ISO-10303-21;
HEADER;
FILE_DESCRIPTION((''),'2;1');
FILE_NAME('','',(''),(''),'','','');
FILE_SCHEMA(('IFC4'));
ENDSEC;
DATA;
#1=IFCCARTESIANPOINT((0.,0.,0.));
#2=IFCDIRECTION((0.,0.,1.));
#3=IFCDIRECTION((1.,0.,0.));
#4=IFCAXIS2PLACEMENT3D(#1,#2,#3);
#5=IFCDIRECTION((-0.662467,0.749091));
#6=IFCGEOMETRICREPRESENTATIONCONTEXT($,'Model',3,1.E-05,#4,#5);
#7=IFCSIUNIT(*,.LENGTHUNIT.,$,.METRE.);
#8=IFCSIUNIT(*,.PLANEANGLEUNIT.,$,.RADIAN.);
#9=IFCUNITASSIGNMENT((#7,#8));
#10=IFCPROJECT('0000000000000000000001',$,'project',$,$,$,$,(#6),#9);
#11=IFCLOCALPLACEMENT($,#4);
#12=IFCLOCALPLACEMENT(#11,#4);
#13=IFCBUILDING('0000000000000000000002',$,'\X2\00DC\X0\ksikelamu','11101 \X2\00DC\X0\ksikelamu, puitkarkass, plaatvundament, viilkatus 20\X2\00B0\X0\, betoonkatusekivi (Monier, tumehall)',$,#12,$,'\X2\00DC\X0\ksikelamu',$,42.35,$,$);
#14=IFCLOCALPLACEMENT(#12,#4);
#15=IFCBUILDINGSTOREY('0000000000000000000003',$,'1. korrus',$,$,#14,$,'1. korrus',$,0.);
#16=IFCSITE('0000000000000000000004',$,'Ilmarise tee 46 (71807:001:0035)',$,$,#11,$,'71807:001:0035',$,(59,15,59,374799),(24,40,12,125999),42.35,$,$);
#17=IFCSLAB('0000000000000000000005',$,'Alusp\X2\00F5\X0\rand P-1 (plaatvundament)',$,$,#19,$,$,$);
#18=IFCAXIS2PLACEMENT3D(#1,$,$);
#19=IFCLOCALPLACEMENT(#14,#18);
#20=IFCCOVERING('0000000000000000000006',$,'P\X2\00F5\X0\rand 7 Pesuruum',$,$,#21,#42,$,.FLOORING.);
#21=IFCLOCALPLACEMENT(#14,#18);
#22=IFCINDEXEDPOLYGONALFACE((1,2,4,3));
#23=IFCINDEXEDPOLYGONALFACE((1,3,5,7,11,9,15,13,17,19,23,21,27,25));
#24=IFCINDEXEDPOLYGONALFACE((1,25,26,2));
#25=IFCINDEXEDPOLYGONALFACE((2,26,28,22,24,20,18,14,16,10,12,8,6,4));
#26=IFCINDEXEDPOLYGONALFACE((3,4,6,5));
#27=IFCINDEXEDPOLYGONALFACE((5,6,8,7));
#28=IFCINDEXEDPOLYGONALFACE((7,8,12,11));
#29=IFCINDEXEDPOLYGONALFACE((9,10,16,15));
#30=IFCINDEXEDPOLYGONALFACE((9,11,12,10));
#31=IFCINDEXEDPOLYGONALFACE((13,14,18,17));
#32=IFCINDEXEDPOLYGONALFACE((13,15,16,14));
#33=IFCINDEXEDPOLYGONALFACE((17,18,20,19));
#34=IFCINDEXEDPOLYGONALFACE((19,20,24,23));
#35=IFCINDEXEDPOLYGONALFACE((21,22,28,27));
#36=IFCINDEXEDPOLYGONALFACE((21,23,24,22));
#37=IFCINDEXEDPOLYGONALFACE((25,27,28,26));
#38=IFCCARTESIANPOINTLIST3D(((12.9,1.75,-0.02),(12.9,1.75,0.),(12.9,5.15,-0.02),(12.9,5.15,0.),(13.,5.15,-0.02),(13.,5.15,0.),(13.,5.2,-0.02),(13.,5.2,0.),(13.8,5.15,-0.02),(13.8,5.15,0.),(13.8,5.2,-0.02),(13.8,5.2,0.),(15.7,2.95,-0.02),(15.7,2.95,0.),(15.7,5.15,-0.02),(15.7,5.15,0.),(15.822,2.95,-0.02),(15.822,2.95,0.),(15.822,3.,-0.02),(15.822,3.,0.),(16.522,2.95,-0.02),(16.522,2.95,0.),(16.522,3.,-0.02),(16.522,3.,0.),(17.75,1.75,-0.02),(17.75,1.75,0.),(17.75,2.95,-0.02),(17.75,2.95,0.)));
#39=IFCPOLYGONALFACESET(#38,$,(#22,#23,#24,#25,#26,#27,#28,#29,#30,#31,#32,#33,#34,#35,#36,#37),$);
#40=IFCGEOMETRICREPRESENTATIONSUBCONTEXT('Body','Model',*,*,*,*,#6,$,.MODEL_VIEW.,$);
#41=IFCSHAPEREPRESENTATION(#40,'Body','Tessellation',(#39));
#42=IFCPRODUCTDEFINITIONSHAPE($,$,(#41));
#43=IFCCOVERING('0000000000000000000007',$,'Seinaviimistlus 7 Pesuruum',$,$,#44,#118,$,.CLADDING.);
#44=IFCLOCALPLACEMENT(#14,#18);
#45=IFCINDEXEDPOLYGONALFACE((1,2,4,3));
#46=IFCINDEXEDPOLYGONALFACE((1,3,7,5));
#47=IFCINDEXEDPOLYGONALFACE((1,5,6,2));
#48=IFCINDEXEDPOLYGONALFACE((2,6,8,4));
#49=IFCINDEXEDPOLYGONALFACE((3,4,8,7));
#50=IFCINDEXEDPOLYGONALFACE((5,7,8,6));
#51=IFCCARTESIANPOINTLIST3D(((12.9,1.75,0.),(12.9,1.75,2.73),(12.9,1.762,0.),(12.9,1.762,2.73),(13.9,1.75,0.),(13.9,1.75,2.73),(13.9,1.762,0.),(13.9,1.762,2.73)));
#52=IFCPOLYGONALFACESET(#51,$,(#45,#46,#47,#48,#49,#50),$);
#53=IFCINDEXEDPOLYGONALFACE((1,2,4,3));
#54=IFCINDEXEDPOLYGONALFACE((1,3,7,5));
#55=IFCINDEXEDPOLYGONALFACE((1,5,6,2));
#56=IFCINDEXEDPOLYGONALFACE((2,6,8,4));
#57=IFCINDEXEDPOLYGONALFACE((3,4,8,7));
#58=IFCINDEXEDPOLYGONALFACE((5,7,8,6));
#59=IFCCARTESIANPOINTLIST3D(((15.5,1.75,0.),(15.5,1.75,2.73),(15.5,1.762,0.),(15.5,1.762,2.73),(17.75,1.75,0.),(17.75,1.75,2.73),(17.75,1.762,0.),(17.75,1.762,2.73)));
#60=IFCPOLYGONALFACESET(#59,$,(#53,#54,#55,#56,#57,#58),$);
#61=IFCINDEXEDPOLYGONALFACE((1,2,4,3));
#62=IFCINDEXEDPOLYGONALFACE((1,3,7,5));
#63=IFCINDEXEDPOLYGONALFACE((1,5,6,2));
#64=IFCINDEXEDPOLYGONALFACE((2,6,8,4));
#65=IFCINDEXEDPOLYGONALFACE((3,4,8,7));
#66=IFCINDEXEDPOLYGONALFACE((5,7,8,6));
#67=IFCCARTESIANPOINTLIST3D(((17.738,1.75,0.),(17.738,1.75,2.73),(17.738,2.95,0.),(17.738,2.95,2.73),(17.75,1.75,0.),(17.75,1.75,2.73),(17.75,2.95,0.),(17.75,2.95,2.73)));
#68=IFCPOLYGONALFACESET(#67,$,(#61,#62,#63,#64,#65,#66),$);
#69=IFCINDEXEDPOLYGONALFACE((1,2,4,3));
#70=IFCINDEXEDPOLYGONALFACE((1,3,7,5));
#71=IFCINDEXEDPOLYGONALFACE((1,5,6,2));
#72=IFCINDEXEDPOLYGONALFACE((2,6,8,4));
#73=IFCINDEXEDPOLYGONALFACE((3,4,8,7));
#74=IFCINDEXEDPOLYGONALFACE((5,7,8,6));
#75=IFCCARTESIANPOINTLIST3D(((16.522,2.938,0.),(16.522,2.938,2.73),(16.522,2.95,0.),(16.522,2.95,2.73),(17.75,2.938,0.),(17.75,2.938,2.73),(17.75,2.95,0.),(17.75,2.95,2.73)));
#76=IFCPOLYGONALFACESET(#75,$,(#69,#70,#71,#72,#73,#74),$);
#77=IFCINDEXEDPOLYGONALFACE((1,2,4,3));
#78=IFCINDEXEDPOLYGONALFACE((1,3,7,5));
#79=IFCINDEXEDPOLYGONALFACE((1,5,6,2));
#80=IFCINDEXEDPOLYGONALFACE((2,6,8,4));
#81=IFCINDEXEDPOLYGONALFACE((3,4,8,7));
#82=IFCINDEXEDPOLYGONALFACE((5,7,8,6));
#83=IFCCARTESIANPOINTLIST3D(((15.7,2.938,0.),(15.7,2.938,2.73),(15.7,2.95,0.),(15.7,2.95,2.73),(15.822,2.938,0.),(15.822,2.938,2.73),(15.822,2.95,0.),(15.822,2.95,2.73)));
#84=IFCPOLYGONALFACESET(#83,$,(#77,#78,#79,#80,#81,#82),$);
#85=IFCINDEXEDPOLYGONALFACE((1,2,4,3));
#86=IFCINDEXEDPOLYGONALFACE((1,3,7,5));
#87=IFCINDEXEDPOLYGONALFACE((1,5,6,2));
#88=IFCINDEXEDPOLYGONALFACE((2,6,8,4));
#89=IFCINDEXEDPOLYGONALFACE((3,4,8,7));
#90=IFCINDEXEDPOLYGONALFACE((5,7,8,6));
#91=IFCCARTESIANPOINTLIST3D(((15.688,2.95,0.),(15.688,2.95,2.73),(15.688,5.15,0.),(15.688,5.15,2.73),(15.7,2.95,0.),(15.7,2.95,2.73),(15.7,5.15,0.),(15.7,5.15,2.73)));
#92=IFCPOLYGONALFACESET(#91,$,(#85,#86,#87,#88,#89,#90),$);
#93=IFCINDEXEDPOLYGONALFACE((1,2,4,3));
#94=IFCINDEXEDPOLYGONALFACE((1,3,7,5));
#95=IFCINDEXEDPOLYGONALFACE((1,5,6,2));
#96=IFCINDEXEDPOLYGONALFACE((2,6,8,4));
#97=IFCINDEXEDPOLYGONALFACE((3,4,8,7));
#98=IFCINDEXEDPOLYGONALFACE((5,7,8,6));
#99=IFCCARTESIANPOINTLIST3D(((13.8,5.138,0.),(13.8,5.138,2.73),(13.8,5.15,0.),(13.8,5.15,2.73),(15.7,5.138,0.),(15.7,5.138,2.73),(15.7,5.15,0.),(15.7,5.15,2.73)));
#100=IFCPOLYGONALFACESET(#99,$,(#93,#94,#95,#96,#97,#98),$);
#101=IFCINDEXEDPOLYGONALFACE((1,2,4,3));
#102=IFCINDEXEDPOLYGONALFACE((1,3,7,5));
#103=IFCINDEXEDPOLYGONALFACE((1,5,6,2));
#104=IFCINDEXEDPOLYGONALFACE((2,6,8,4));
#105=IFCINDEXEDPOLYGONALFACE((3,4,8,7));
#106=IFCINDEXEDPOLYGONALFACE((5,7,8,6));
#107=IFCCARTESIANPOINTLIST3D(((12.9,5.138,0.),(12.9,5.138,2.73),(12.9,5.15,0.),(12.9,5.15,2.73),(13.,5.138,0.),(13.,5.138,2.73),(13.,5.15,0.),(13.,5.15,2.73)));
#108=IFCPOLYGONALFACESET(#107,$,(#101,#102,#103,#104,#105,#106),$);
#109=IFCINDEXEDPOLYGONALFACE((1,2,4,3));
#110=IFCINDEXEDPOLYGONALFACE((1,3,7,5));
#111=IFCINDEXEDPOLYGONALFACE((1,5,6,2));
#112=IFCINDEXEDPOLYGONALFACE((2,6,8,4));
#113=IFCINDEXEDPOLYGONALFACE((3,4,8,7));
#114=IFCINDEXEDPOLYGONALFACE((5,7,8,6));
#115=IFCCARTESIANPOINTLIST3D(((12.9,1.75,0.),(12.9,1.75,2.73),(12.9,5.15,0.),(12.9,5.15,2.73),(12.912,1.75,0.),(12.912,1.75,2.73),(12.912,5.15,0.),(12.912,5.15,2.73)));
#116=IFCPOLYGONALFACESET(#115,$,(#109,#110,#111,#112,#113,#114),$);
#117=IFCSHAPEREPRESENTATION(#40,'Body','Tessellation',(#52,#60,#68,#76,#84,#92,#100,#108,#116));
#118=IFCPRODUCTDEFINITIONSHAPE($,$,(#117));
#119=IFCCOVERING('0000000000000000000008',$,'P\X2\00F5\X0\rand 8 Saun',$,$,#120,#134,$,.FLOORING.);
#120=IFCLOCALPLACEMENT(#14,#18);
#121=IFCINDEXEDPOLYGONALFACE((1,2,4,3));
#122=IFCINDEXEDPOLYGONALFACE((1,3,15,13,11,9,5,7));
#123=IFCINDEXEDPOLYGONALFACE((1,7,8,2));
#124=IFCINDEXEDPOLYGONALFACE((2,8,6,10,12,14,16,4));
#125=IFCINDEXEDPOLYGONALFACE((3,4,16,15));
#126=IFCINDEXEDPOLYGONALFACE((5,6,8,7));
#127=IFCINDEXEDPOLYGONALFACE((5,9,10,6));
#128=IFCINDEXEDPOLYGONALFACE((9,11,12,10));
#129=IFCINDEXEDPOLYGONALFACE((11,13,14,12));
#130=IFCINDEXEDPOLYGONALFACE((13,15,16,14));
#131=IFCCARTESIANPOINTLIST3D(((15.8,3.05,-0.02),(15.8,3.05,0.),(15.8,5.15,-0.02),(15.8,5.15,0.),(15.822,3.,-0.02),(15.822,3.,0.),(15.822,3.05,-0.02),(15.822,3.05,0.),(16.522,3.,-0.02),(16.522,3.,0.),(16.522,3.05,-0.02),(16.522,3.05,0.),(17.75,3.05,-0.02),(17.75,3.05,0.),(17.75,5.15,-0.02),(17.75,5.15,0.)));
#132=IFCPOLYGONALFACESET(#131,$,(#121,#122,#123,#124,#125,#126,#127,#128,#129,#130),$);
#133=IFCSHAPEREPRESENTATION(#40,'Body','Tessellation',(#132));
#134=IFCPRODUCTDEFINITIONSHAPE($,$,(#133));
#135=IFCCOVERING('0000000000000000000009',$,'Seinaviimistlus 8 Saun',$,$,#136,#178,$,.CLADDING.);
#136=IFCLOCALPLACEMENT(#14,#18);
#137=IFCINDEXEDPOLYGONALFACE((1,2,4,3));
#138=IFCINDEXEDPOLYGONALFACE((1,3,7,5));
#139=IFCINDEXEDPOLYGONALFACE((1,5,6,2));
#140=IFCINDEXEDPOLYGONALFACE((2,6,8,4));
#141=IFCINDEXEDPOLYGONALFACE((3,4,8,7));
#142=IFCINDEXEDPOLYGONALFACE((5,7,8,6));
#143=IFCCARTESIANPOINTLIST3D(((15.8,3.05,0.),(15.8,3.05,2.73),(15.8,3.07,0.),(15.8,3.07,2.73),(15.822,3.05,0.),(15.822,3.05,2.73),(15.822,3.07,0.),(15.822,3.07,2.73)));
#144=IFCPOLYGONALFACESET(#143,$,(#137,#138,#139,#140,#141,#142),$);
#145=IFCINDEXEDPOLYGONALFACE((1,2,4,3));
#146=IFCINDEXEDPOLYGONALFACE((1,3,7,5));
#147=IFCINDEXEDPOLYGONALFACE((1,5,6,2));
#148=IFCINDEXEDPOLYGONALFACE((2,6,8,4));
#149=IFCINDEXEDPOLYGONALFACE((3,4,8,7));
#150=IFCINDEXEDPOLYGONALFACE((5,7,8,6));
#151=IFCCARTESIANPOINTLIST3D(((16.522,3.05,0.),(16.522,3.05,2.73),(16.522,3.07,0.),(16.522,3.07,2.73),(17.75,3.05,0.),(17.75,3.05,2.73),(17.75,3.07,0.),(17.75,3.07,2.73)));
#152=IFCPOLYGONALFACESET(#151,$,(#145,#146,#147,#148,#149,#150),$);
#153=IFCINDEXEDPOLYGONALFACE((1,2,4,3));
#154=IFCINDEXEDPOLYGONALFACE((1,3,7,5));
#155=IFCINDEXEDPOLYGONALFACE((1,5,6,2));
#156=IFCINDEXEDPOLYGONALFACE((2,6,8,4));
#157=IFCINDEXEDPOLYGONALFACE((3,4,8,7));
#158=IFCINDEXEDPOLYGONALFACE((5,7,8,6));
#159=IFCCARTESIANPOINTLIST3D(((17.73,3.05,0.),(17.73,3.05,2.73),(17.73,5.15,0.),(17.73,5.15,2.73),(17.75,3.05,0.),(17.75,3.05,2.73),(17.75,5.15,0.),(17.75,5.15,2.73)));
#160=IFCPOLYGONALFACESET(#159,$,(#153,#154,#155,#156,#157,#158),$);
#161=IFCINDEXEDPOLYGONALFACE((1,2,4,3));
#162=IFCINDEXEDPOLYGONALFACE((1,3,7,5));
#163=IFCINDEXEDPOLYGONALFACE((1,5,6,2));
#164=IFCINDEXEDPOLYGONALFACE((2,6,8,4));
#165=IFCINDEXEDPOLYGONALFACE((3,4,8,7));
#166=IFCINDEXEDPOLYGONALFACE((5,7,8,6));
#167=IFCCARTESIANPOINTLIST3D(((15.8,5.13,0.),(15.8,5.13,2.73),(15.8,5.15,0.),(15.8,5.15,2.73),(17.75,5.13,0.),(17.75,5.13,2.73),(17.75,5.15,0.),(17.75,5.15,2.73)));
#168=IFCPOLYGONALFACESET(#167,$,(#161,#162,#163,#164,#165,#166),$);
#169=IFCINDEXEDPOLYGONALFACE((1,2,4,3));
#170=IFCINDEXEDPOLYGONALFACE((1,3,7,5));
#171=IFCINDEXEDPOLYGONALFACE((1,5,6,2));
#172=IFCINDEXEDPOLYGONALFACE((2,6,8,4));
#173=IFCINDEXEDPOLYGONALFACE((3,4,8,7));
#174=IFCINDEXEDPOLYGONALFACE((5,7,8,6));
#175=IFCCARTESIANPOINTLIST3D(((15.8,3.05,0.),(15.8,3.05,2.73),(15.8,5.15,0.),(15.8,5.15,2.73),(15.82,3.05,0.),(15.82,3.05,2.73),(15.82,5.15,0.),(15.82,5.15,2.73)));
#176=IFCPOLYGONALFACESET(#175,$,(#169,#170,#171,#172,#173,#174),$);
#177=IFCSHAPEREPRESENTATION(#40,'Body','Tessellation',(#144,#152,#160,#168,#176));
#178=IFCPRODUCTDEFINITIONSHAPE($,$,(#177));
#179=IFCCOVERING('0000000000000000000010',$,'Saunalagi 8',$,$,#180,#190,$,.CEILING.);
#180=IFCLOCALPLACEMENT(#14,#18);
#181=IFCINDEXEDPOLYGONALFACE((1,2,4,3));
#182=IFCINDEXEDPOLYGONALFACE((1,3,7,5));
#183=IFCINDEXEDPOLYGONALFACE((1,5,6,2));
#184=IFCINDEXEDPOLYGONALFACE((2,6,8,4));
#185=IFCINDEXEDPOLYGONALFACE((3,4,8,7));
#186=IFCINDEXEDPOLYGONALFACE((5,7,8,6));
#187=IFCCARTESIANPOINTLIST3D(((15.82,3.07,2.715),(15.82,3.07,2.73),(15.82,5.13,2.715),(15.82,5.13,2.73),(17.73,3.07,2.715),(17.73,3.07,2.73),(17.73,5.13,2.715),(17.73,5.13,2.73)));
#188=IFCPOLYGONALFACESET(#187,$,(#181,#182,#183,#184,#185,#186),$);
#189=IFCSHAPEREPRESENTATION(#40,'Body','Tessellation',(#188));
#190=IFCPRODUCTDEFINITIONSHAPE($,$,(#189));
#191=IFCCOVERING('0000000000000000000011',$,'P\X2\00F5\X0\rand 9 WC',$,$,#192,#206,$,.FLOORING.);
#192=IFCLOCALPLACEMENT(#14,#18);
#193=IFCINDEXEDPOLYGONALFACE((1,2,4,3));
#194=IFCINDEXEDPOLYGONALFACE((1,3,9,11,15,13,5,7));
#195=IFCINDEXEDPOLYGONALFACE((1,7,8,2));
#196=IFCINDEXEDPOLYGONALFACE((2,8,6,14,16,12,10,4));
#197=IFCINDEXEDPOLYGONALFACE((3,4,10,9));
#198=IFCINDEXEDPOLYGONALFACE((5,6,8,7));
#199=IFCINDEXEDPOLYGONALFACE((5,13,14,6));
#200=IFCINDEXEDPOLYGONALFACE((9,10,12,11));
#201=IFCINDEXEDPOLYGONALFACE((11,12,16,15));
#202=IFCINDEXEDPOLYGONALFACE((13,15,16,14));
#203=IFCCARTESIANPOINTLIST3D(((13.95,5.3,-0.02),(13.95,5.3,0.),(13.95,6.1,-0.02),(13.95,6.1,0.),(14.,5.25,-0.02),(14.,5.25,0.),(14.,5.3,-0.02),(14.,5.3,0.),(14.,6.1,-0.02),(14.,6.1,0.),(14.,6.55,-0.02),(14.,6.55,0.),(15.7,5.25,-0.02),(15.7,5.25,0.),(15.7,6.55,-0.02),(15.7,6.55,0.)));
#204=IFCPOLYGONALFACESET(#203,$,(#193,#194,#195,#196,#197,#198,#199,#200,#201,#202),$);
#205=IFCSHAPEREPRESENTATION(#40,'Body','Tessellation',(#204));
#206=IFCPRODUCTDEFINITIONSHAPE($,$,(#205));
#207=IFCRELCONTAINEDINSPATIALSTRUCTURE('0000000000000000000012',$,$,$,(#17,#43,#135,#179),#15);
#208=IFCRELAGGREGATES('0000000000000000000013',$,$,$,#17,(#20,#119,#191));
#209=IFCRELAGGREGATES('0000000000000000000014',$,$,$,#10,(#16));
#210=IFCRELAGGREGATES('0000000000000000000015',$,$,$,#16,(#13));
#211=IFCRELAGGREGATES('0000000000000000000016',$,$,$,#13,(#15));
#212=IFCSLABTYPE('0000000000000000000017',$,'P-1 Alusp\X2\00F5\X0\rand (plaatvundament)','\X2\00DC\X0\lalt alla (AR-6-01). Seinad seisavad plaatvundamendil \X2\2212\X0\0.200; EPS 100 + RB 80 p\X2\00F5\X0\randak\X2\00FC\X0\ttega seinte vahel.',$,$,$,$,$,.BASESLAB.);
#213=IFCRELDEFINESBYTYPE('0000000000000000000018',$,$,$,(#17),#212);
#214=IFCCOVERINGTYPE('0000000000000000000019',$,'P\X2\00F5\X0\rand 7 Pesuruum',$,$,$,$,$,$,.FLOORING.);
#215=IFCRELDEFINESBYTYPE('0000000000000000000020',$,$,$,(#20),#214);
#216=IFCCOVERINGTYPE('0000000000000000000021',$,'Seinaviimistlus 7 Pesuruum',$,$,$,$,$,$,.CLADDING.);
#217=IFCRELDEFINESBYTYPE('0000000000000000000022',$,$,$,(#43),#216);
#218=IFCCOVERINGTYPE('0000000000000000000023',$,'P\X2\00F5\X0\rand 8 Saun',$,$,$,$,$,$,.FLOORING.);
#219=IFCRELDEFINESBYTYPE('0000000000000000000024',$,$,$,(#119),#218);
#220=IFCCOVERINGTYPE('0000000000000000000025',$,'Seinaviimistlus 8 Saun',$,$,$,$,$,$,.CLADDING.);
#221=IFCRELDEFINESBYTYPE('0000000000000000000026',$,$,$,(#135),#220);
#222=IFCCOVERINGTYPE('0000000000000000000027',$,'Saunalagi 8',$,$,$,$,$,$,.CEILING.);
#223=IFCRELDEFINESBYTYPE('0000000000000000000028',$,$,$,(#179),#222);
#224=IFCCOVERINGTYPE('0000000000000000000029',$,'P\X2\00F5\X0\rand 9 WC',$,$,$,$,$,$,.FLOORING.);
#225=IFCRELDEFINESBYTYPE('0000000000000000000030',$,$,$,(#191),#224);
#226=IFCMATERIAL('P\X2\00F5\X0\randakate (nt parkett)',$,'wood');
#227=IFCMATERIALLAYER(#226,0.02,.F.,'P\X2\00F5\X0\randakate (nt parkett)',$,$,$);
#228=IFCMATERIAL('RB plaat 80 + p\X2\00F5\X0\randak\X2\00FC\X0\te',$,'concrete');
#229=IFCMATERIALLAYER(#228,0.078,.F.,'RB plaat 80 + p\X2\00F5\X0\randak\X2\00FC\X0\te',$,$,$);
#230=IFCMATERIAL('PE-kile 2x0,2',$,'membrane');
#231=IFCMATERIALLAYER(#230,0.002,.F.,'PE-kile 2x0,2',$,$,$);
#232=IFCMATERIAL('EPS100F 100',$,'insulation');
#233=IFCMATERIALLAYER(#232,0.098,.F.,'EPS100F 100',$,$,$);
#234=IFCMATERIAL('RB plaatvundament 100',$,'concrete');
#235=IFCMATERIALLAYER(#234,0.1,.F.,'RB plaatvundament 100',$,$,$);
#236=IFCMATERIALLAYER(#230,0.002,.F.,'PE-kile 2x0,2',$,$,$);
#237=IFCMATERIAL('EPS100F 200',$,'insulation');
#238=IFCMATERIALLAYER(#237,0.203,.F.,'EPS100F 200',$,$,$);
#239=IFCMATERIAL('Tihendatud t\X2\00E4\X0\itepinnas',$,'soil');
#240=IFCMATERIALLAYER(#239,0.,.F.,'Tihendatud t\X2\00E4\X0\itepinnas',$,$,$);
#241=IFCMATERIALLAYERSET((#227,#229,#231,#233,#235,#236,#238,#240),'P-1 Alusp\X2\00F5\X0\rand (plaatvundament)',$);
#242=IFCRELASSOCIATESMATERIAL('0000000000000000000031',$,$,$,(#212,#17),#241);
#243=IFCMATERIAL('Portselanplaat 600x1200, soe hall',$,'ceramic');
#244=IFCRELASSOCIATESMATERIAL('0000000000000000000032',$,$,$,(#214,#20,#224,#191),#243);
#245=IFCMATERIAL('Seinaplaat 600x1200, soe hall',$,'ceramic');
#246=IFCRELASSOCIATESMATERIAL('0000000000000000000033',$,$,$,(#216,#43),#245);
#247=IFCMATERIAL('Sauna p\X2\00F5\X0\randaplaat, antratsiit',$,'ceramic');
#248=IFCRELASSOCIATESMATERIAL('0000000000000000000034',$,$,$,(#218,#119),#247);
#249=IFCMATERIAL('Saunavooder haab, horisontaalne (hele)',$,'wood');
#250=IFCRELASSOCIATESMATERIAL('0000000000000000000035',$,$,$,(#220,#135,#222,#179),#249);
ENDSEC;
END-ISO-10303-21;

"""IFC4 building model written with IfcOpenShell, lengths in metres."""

from ifc_helpers import new_model, si_unit, direction, frame, origin_with_axes, place, context, subcontext, project, spatial, indexed_curve, outline, extrude, material, layer, layer_set, layer_usage, type_object, element, aggregate, save


model = new_model("IFC4")

# Units and contexts
model_context = context("Model", 3, precision=1e-05, world=origin_with_axes(), true_north=direction((-0.662467, 0.749091)))
body_context = subcontext(model_context, "Body", "Model", "MODEL_VIEW")
ifc_project = project(units=[si_unit("LENGTHUNIT", "METRE"), si_unit("PLANEANGLEUNIT", "RADIAN")], contexts=[model_context])

# Site, building, storey
site_placement = place(None, origin_with_axes())
site = spatial("IfcSite", under=ifc_project, at=site_placement, Name="Ilmarise tee 46 (71807:001:0035)", LongName="71807:001:0035", RefLatitude=(59, 15, 59, 374799), RefLongitude=(24, 40, 12, 125999), RefElevation=42.35)
building_placement = place(site_placement, origin_with_axes())
building = spatial("IfcBuilding", under=site, at=building_placement, Name="Üksikelamu", Description="11101 Üksikelamu, puitkarkass, plaatvundament, viilkatus 20°, betoonkatusekivi (Monier, tumehall)", LongName="Üksikelamu", ElevationOfRefHeight=42.35)
storey_placement = place(building_placement, origin_with_axes())
storey = spatial("IfcBuildingStorey", under=building, at=storey_placement, Name="1. korrus", LongName="1. korrus", Elevation=0.0)

# Slab
ifc_material_1 = material(Name="Põrandakate (nt parkett)", Category="wood")
ifc_layer_1 = layer(ifc_material_1, 0.02, ventilated=False, Name="Põrandakate (nt parkett)")
ifc_material_2 = material(Name="RB plaat 80 + põrandaküte", Category="concrete")
ifc_layer_2 = layer(ifc_material_2, 0.078, ventilated=False, Name="RB plaat 80 + põrandaküte")
ifc_material_3 = material(Name="PE-kile 2x0,2", Category="membrane")
ifc_layer_3 = layer(ifc_material_3, 0.002, ventilated=False, Name="PE-kile 2x0,2")
ifc_material_4 = material(Name="EPS100F 100", Category="insulation")
ifc_layer_4 = layer(ifc_material_4, 0.098, ventilated=False, Name="EPS100F 100")
ifc_material_5 = material(Name="RB plaatvundament 100", Category="concrete")
ifc_layer_5 = layer(ifc_material_5, 0.1, ventilated=False, Name="RB plaatvundament 100")
ifc_layer_6 = layer(ifc_material_3, 0.002, ventilated=False, Name="PE-kile 2x0,2")
ifc_material_6 = material(Name="EPS100F 200", Category="insulation")
ifc_layer_7 = layer(ifc_material_6, 0.203, ventilated=False, Name="EPS100F 200")
ifc_material_7 = material(Name="Tihendatud täitepinnas", Category="soil")
ifc_layer_8 = layer(ifc_material_7, 0.0, ventilated=False, Name="Tihendatud täitepinnas")
ifc_layer_set_1 = layer_set([ifc_layer_1, ifc_layer_2, ifc_layer_3, ifc_layer_4, ifc_layer_5, ifc_layer_6, ifc_layer_7, ifc_layer_8], Name="P-1 Aluspõrand (plaatvundament)")
ifc_layer_usage_1 = layer_usage(ifc_layer_set_1, "AXIS3", "NEGATIVE", 0.0)
slab_type = type_object("IfcSlabType", Name="P-1 Aluspõrand (plaatvundament)", Description="Ülalt alla (AR-6-01). Seinad seisavad plaatvundamendil −0.200; EPS 100 + RB 80 põrandaküttega seinte vahel.", PredefinedType="BASESLAB", material=ifc_layer_set_1)
slab_placement = place(storey_placement, origin_with_axes())
slab = element("IfcSlab", 1, at=slab_placement, inside=storey, type_object=slab_type, material=ifc_layer_usage_1, Name="Aluspõrand P-1 (plaatvundament)")

# Coverings
ifc_material_8 = material(Name="Portselanplaat 600x1200, soe hall", Category="ceramic")
covering_type_1 = type_object("IfcCoveringType", Name="Põrand 7 Pesuruum", PredefinedType="FLOORING", material=ifc_material_8)
covering_1_placement = place(slab_placement, origin_with_axes())
covering_1 = element("IfcCovering", 2, at=covering_1_placement, type_object=covering_type_1, material=ifc_material_8, Name="Põrand 7 Pesuruum", PredefinedType="FLOORING", context=body_context, shape_type="SweptSolid", body=[
    extrude(outline(indexed_curve([(13.0, 5.15), (13.0, 5.2), (13.8, 5.2), (13.8, 5.15), (15.7, 5.15), (15.7, 2.95), (15.822, 2.95), (15.822, 3.0), (16.522, 3.0), (16.522, 2.95), (17.75, 2.95), (17.75, 1.75), (12.9, 1.75), (12.9, 5.15), (13.0, 5.15)], self_intersect=False)), frame((0.0, 0.0, -0.02), z_axis=(0.0, 0.0, 1.0), x_axis=(1.0, 0.0, 0.0)), (0.0, 0.0, 1.0), 0.02),
])
ifc_material_9 = material(Name="Seinaplaat 600x1200, soe hall", Category="ceramic")
covering_type_2 = type_object("IfcCoveringType", Name="Seinaviimistlus 7 Pesuruum", PredefinedType="CLADDING", material=ifc_material_9)
covering_2_placement = place(storey_placement, origin_with_axes())
element("IfcCovering", 3, at=covering_2_placement, inside=storey, type_object=covering_type_2, material=ifc_material_9, Name="Seinaviimistlus 7 Pesuruum", PredefinedType="CLADDING", context=body_context, shape_type="SweptSolid", body=[
    extrude(outline(indexed_curve([(12.9, 1.75), (12.9, 1.762), (13.9, 1.762), (13.9, 1.75), (12.9, 1.75)], self_intersect=False)), origin_with_axes(), (0.0, 0.0, 1.0), 2.73),
    extrude(outline(indexed_curve([(17.75, 1.762), (17.75, 1.75), (15.5, 1.75), (15.5, 1.762), (17.75, 1.762)], self_intersect=False)), origin_with_axes(), (0.0, 0.0, 1.0), 2.73),
    extrude(outline(indexed_curve([(17.738, 1.75), (17.738, 2.95), (17.75, 2.95), (17.75, 1.75), (17.738, 1.75)], self_intersect=False)), origin_with_axes(), (0.0, 0.0, 1.0), 2.73),
    extrude(outline(indexed_curve([(17.75, 2.95), (17.75, 2.938), (16.522, 2.938), (16.522, 2.95), (17.75, 2.95)], self_intersect=False)), origin_with_axes(), (0.0, 0.0, 1.0), 2.73),
    extrude(outline(indexed_curve([(15.7, 2.938), (15.7, 2.95), (15.822, 2.95), (15.822, 2.938), (15.7, 2.938)], self_intersect=False)), origin_with_axes(), (0.0, 0.0, 1.0), 2.73),
    extrude(outline(indexed_curve([(15.688, 2.95), (15.688, 5.15), (15.7, 5.15), (15.7, 2.95), (15.688, 2.95)], self_intersect=False)), origin_with_axes(), (0.0, 0.0, 1.0), 2.73),
    extrude(outline(indexed_curve([(15.7, 5.15), (15.7, 5.138), (13.8, 5.138), (13.8, 5.15), (15.7, 5.15)], self_intersect=False)), origin_with_axes(), (0.0, 0.0, 1.0), 2.73),
    extrude(outline(indexed_curve([(12.9, 5.138), (12.9, 5.15), (13.0, 5.15), (13.0, 5.138), (12.9, 5.138)], self_intersect=False)), origin_with_axes(), (0.0, 0.0, 1.0), 2.73),
    extrude(outline(indexed_curve([(12.912, 5.15), (12.912, 1.75), (12.9, 1.75), (12.9, 5.15), (12.912, 5.15)], self_intersect=False)), origin_with_axes(), (0.0, 0.0, 1.0), 2.73),
])
ifc_material_10 = material(Name="Sauna põrandaplaat, antratsiit", Category="ceramic")
covering_type_3 = type_object("IfcCoveringType", Name="Põrand 8 Saun", PredefinedType="FLOORING", material=ifc_material_10)
covering_3_placement = place(slab_placement, origin_with_axes())
covering_3 = element("IfcCovering", 4, at=covering_3_placement, type_object=covering_type_3, material=ifc_material_10, Name="Põrand 8 Saun", PredefinedType="FLOORING", context=body_context, shape_type="SweptSolid", body=[
    extrude(outline(indexed_curve([(15.8, 5.15), (17.75, 5.15), (17.75, 3.05), (16.522, 3.05), (16.522, 3.0), (15.822, 3.0), (15.822, 3.05), (15.8, 3.05), (15.8, 5.15)], self_intersect=False)), frame((0.0, 0.0, -0.02), z_axis=(0.0, 0.0, 1.0), x_axis=(1.0, 0.0, 0.0)), (0.0, 0.0, 1.0), 0.02),
])

# Coverings
ifc_material_11 = material(Name="Saunavooder haab, horisontaalne (hele)", Category="wood")
covering_type_4 = type_object("IfcCoveringType", Name="Seinaviimistlus 8 Saun", PredefinedType="CLADDING", material=ifc_material_11)
covering_4_placement = place(storey_placement, origin_with_axes())
element("IfcCovering", 5, at=covering_4_placement, inside=storey, type_object=covering_type_4, material=ifc_material_11, Name="Seinaviimistlus 8 Saun", PredefinedType="CLADDING", context=body_context, shape_type="SweptSolid", body=[
    extrude(outline(indexed_curve([(15.8, 3.05), (15.8, 3.07), (15.822, 3.07), (15.822, 3.05), (15.8, 3.05)], self_intersect=False)), origin_with_axes(), (0.0, 0.0, 1.0), 2.73),
    extrude(outline(indexed_curve([(17.75, 3.07), (17.75, 3.05), (16.522, 3.05), (16.522, 3.07), (17.75, 3.07)], self_intersect=False)), origin_with_axes(), (0.0, 0.0, 1.0), 2.73),
    extrude(outline(indexed_curve([(17.73, 3.05), (17.73, 5.15), (17.75, 5.15), (17.75, 3.05), (17.73, 3.05)], self_intersect=False)), origin_with_axes(), (0.0, 0.0, 1.0), 2.73),
    extrude(outline(indexed_curve([(17.75, 5.13), (15.8, 5.13), (15.8, 5.15), (17.75, 5.15), (17.75, 5.13)], self_intersect=False)), origin_with_axes(), (0.0, 0.0, 1.0), 2.73),
    extrude(outline(indexed_curve([(15.82, 5.15), (15.82, 3.05), (15.8, 3.05), (15.8, 5.15), (15.82, 5.15)], self_intersect=False)), origin_with_axes(), (0.0, 0.0, 1.0), 2.73),
])
covering_type_5 = type_object("IfcCoveringType", Name="Saunalagi 8", PredefinedType="CEILING", material=ifc_material_11)
covering_5_placement = place(storey_placement, origin_with_axes())
element("IfcCovering", 6, at=covering_5_placement, inside=storey, type_object=covering_type_5, material=ifc_material_11, Name="Saunalagi 8", PredefinedType="CEILING", context=body_context, shape_type="SweptSolid", body=[
    extrude(outline(indexed_curve([(15.82, 3.07), (15.82, 5.13), (17.73, 5.13), (17.73, 3.07), (15.82, 3.07)], self_intersect=False)), frame((0.0, 0.0, 2.715), z_axis=(0.0, 0.0, 1.0), x_axis=(1.0, 0.0, 0.0)), (0.0, 0.0, 1.0), 0.015),
])

# Covering
covering_type_6 = type_object("IfcCoveringType", Name="Põrand 9 WC", PredefinedType="FLOORING", material=ifc_material_8)
covering_6_placement = place(slab_placement, origin_with_axes())
covering_6 = element("IfcCovering", 7, at=covering_6_placement, type_object=covering_type_6, material=ifc_material_8, Name="Põrand 9 WC", PredefinedType="FLOORING", context=body_context, shape_type="SweptSolid", body=[
    extrude(outline(indexed_curve([(14.0, 5.3), (13.95, 5.3), (13.95, 6.1), (14.0, 6.1), (14.0, 6.55), (15.7, 6.55), (15.7, 5.25), (14.0, 5.25), (14.0, 5.3)], self_intersect=False)), frame((0.0, 0.0, -0.02), z_axis=(0.0, 0.0, 1.0), x_axis=(1.0, 0.0, 0.0)), (0.0, 0.0, 1.0), 0.02),
])
aggregate(slab, [covering_1, covering_3, covering_6])

save(model, "model.ifc")
